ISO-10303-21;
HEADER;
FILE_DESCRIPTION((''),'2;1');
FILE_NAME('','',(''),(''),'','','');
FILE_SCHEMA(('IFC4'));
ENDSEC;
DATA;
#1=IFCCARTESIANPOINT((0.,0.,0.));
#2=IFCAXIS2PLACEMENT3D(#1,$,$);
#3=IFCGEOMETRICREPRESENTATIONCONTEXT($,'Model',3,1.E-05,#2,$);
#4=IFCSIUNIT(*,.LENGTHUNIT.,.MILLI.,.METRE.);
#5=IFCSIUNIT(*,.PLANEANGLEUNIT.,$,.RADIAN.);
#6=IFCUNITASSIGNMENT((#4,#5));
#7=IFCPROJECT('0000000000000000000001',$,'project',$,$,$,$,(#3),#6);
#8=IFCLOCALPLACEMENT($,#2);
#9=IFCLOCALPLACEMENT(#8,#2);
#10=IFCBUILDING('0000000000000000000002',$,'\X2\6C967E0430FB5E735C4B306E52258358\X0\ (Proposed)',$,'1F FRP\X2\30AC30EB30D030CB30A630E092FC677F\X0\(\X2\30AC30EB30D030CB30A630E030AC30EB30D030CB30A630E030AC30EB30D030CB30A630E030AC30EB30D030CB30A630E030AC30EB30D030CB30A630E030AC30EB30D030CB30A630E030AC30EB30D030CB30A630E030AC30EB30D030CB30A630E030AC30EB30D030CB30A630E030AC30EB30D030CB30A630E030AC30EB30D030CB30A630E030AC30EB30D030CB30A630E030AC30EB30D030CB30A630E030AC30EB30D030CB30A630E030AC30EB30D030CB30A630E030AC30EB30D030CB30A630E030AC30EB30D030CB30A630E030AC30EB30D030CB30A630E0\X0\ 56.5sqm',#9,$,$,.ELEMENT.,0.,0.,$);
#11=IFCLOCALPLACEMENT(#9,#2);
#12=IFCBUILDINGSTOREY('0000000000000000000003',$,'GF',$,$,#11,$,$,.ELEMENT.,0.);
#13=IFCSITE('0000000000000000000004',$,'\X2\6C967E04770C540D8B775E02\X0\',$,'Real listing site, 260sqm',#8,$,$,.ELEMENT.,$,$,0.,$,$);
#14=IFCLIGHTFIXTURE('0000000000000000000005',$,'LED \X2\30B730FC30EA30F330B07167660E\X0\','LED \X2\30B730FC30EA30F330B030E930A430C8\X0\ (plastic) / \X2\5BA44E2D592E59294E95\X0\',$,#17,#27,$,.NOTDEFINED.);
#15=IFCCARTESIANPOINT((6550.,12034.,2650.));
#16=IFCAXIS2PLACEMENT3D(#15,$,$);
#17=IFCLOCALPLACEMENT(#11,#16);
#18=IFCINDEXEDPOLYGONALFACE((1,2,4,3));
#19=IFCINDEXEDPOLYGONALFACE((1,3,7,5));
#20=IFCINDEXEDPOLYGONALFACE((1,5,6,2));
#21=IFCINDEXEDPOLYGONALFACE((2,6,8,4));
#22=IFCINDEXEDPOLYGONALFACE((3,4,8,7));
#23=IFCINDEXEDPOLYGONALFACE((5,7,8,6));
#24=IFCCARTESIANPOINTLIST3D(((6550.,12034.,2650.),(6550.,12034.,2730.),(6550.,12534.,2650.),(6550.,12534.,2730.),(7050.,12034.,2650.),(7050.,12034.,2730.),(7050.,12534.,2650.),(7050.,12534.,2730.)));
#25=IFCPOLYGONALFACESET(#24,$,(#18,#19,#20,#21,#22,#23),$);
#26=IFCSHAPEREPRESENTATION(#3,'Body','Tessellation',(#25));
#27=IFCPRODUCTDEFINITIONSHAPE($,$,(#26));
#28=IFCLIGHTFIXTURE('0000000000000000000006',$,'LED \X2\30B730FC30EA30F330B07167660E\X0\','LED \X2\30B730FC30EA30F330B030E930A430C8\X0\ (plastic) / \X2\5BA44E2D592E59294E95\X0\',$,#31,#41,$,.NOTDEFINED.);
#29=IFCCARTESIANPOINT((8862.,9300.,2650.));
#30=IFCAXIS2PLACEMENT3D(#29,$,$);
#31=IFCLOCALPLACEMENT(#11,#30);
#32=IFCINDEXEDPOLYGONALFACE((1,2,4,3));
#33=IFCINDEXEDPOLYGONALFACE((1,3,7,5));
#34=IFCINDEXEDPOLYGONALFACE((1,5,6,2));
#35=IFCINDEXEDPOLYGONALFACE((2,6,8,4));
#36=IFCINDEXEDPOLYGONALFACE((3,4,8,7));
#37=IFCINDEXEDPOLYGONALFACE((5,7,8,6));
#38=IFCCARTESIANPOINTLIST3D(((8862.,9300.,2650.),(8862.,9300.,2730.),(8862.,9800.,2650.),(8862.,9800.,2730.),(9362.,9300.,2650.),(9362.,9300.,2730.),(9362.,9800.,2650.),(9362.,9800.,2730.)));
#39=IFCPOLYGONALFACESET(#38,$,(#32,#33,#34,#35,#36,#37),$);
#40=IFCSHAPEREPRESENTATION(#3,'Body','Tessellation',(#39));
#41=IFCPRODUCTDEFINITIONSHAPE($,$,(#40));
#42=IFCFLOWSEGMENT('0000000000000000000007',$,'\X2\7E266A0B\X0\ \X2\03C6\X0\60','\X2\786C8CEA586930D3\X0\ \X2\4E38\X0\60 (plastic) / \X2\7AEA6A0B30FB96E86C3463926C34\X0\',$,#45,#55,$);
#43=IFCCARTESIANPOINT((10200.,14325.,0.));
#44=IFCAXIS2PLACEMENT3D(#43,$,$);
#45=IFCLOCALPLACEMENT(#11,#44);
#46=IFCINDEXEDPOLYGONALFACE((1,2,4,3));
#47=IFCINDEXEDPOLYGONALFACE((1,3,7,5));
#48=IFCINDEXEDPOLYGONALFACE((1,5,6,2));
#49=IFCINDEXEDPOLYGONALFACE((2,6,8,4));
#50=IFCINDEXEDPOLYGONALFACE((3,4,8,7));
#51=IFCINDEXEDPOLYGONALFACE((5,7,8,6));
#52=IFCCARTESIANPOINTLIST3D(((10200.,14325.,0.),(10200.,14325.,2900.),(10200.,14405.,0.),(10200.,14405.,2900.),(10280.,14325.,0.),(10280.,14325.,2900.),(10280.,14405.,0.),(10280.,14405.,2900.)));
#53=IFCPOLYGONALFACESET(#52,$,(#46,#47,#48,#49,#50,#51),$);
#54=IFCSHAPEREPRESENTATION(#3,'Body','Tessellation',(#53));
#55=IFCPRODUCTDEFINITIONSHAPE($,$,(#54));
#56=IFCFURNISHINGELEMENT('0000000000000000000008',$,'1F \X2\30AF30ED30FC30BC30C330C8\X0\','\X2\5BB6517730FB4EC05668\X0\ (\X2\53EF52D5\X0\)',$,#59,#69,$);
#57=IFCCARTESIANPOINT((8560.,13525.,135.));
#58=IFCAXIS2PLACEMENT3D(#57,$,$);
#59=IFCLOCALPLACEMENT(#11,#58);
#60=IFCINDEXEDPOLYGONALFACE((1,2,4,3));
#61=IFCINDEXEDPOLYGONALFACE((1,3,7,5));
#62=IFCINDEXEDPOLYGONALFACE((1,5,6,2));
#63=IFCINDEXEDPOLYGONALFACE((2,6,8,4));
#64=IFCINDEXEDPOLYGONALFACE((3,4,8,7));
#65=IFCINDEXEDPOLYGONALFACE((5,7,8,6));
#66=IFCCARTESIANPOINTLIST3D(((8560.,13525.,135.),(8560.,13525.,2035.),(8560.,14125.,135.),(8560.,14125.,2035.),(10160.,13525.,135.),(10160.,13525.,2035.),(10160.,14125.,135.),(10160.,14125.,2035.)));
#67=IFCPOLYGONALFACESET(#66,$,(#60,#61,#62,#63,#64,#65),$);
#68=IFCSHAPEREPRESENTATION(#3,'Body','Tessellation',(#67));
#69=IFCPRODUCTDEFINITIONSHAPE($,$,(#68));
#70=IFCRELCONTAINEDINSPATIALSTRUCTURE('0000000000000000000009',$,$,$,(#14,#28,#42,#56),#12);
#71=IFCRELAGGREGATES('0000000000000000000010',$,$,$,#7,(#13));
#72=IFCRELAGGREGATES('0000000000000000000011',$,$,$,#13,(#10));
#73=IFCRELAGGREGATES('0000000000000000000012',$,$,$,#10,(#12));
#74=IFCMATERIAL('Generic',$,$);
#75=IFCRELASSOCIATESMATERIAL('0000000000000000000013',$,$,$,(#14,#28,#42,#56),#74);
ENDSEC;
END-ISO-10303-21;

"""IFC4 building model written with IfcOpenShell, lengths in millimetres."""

from ifc_helpers import new_model, si_unit, frame, frame_2d, origin, place, context, project, spatial, rectangle, extrude, material, element, save


model = new_model("IFC4")

# Units and contexts
model_context = context("Model", 3, precision=1e-05, world=origin())
ifc_project = project(units=[si_unit("LENGTHUNIT", "METRE", prefix="MILLI"), si_unit("PLANEANGLEUNIT", "RADIAN")], contexts=[model_context])

# Site, building, storey
site_placement = place(None, origin())
site = spatial("IfcSite", under=ifc_project, at=site_placement, Name="沖縄県名護市", ObjectType="Real listing site, 260sqm", CompositionType="ELEMENT", RefElevation=0.0)
building_placement = place(site_placement, origin())
building = spatial("IfcBuilding", under=site, at=building_placement, Name="沖縄・平屋の別荘 (Proposed)", ObjectType="1F FRPガルバニウム鋼板(ガルバニウムガルバニウムガルバニウムガルバニウムガルバニウムガルバニウムガルバニウムガルバニウムガルバニウムガルバニウムガルバニウムガルバニウムガルバニウムガルバニウムガルバニウムガルバニウムガルバニウムガルバニウム 56.5sqm", CompositionType="ELEMENT", ElevationOfRefHeight=0.0, ElevationOfTerrain=0.0)
storey_placement = place(building_placement, origin())
storey = spatial("IfcBuildingStorey", under=building, at=storey_placement, Name="GF", CompositionType="ELEMENT", Elevation=0.0)

# Shared definitions
ifc_material_1 = material(Name="Generic")

# Light fixtures
light_fixture_1_placement = place(storey_placement, frame((6550.0, 12034.0, 2650.0)))
element("IfcLightFixture", 1, at=light_fixture_1_placement, inside=storey, material=ifc_material_1, Name="LED シーリング照明", Description="LED シーリングライト (plastic) / 室中央天井", PredefinedType="NOTDEFINED", context=model_context, shape_type="SweptSolid", body=[
    extrude(rectangle(XDim=500.0, YDim=500.0, at=frame_2d((250.0, 250.0))), frame((6550.0, 12034.0, 2650.0)), (0.0, 0.0, 1.0), 80.0),
])
light_fixture_2_placement = place(storey_placement, frame((8862.0, 9300.0, 2650.0)))
element("IfcLightFixture", 2, at=light_fixture_2_placement, inside=storey, material=ifc_material_1, Name="LED シーリング照明", Description="LED シーリングライト (plastic) / 室中央天井", PredefinedType="NOTDEFINED", context=model_context, shape_type="SweptSolid", body=[
    extrude(rectangle(XDim=500.0, YDim=500.0, at=frame_2d((250.0, 250.0))), frame((8862.0, 9300.0, 2650.0)), (0.0, 0.0, 1.0), 80.0),
])

# Flow segment
flow_segment_placement = place(storey_placement, frame((10200.0, 14325.0, 0.0)))
element("IfcFlowSegment", 3, at=flow_segment_placement, inside=storey, material=ifc_material_1, Name="縦樋 φ60", Description="硬質塩ビ 丸60 (plastic) / 竪樋・雨水排水", context=model_context, shape_type="SweptSolid", body=[
    extrude(rectangle(XDim=80.0, YDim=80.0, at=frame_2d((40.0, 40.0))), frame((10200.0, 14325.0, 0.0)), (0.0, 0.0, 1.0), 2900.0),
])

# Furnishing element
furnishing_placement = place(storey_placement, frame((8560.0, 13525.0, 135.0)))
element("IfcFurnishingElement", 4, at=furnishing_placement, inside=storey, material=ifc_material_1, Name="1F クローゼット", Description="家具・什器 (可動)", context=model_context, shape_type="SweptSolid", body=[
    extrude(rectangle(XDim=1600.0, YDim=600.0, at=frame_2d((800.0, 300.0))), frame((8560.0, 13525.0, 135.0)), (0.0, 0.0, 1.0), 1900.0),
])

save(model, "model.ifc")
